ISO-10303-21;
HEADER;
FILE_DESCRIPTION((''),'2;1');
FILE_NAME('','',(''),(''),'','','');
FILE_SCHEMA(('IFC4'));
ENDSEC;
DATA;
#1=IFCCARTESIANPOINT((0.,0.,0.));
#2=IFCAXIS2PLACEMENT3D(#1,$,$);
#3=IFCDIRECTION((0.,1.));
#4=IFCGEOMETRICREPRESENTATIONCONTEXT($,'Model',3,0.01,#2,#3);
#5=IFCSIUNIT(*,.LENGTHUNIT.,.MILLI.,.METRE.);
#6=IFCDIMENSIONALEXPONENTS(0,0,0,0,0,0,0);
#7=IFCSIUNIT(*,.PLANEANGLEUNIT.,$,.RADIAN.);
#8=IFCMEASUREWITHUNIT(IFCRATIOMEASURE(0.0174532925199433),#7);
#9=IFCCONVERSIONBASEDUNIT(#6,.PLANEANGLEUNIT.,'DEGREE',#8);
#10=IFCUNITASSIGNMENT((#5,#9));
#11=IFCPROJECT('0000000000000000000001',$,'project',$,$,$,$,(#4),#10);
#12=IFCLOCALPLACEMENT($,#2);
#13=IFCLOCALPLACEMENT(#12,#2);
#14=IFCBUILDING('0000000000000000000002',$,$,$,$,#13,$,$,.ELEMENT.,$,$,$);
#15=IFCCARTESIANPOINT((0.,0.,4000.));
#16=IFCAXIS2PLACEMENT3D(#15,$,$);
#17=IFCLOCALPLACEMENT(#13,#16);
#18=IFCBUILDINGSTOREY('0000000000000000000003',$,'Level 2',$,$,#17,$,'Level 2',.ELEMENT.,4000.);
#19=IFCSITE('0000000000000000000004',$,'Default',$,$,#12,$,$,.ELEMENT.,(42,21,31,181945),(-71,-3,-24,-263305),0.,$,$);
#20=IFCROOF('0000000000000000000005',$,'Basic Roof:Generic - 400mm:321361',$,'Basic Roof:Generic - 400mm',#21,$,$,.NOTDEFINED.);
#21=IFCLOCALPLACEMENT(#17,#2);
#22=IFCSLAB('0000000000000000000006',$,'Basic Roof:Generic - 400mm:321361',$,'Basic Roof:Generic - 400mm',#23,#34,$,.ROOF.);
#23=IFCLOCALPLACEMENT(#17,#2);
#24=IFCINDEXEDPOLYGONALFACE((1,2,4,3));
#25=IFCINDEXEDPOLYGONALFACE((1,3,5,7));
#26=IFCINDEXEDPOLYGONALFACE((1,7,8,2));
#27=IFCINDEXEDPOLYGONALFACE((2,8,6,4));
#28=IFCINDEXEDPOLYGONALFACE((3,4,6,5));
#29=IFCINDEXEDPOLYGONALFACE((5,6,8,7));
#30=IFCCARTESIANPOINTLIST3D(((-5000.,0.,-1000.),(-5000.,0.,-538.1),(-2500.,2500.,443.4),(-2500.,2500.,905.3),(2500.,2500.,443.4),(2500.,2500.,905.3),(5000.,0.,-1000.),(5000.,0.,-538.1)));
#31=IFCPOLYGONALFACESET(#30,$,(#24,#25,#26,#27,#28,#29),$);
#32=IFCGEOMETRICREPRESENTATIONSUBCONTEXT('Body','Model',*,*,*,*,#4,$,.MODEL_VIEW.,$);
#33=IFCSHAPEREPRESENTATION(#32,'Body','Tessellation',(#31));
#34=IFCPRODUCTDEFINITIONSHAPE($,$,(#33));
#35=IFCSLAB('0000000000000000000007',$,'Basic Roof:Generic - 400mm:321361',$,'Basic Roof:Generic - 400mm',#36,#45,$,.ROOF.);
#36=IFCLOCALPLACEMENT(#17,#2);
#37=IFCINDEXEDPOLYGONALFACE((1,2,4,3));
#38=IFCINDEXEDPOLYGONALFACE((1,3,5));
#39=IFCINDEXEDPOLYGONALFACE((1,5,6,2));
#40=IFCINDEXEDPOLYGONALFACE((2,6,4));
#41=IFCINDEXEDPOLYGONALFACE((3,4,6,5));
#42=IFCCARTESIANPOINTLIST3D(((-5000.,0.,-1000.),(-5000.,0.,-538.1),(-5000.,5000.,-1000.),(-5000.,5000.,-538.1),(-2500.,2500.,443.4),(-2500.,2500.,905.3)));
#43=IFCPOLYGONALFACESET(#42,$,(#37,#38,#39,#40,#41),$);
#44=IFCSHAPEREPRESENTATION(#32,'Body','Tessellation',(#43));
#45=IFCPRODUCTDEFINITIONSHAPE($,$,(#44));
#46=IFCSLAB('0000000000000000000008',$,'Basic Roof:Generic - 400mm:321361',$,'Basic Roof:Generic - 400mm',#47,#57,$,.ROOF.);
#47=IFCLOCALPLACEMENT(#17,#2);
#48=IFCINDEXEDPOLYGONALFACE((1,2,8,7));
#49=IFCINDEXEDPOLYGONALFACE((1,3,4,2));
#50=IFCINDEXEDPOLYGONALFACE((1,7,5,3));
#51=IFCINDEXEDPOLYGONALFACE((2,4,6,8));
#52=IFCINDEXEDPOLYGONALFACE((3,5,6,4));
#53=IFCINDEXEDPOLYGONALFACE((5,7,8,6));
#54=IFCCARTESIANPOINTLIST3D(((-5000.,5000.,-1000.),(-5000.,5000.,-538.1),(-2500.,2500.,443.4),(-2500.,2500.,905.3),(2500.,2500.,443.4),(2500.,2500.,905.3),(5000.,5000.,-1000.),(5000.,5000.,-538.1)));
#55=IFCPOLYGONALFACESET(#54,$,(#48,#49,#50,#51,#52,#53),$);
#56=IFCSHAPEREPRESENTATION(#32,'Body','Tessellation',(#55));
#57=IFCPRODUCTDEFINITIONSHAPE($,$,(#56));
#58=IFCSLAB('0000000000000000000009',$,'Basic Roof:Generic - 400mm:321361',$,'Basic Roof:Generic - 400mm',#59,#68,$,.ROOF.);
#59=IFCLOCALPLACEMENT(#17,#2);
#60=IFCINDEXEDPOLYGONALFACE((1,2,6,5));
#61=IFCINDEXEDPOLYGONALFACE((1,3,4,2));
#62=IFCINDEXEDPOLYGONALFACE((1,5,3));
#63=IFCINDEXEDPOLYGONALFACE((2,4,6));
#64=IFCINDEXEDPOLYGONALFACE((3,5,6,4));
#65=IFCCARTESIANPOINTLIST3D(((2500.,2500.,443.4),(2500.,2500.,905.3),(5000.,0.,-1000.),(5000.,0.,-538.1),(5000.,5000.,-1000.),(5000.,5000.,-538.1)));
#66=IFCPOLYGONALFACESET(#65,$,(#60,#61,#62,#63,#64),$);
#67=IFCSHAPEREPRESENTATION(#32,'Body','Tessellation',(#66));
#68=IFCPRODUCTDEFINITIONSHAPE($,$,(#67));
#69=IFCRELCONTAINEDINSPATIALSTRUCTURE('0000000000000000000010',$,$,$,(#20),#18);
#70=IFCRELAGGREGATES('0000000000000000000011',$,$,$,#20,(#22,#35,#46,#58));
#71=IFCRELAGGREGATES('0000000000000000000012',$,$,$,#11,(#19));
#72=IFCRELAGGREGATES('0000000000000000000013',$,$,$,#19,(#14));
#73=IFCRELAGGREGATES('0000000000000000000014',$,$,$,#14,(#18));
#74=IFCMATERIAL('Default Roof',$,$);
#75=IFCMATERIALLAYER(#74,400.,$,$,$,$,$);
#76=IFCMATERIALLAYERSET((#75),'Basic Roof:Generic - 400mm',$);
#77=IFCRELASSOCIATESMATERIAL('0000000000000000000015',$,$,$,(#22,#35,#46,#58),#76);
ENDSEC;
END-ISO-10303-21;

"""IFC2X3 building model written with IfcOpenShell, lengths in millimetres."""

from ifc_helpers import new_model, entity, si_unit, converted_unit, direction, frame, origin, place, context, subcontext, project, spatial, polyline, outline, extrude, material, layer, layer_set, element, aggregate, save


model = new_model("IFC2X3")

# Units and contexts
model_context = context("Model", 3, precision=0.01, world=origin(), true_north=direction((0.0, 1.0)))
body_context = subcontext(model_context, "Body", "Model", "MODEL_VIEW")
ifc_project = project(units=[si_unit("LENGTHUNIT", "METRE", prefix="MILLI"), converted_unit("PLANEANGLEUNIT", "DEGREE", entity("IfcRatioMeasure", 0.0174532925199433), si_unit("PLANEANGLEUNIT", "RADIAN"), dimensions=[0, 0, 0, 0, 0, 0, 0])], contexts=[model_context])

# Site, building, storey
site_placement = place(None, origin())
site = spatial("IfcSite", under=ifc_project, at=site_placement, Name="Default", CompositionType="ELEMENT", RefLatitude=(42, 21, 31, 181945), RefLongitude=(-71, -3, -24, -263305), RefElevation=0.0)
building_placement = place(site_placement, origin())
building = spatial("IfcBuilding", under=site, at=building_placement, CompositionType="ELEMENT")
storey_placement = place(building_placement, frame((0.0, 0.0, 4000.0)))
storey = spatial("IfcBuildingStorey", under=building, at=storey_placement, Name="Level 2", LongName="Level 2", CompositionType="ELEMENT", Elevation=4000.0)

# Roof, slabs
roof_placement = place(storey_placement, frame((-5000.0, 0.0, -1000.0)))
roof = element("IfcRoof", 1, at=roof_placement, inside=storey, Name="Basic Roof:Generic - 400mm:321361", ObjectType="Basic Roof:Generic - 400mm", ShapeType="NOTDEFINED")
ifc_material = material(Name="Default Roof")
ifc_layer = layer(ifc_material, 400.0)
ifc_layer_set = layer_set([ifc_layer], Name="Basic Roof:Generic - 400mm")
slab_1_placement = place(roof_placement, origin())
slab_1 = element("IfcSlab", 2, at=slab_1_placement, material=ifc_layer_set, Name="Basic Roof:Generic - 400mm:321361", ObjectType="Basic Roof:Generic - 400mm", PredefinedType="ROOF", context=body_context, shape_type="SweptSolid", body=[
    extrude(outline(polyline([(2500.0, 1443.4), (-2500.0, 1443.4), (-5000.0, -1443.4), (5000.0, -1443.4), (2500.0, 1443.4)])), frame((5000.0, 1250.0, 721.7), z_axis=(0.0, -0.5, 0.866025), x_axis=(1.0, 0.0, 0.0)), (0.0, 0.5, 0.866025), 461.9),
])
slab_2_placement = place(roof_placement, origin())
slab_2 = element("IfcSlab", 3, at=slab_2_placement, material=ifc_layer_set, Name="Basic Roof:Generic - 400mm:321361", ObjectType="Basic Roof:Generic - 400mm", PredefinedType="ROOF", context=body_context, shape_type="SweptSolid", body=[
    extrude(outline(polyline([(-1443.4, 2500.0), (-1443.4, -2500.0), (1443.4, 0.0), (-1443.4, 2500.0)])), frame((1250.0, 2500.0, 721.7), z_axis=(-0.5, 0.0, 0.866025), x_axis=(0.866025, 0.0, 0.5)), (0.5, 0.0, 0.866025), 461.9),
])
slab_3_placement = place(roof_placement, origin())
slab_3 = element("IfcSlab", 4, at=slab_3_placement, material=ifc_layer_set, Name="Basic Roof:Generic - 400mm:321361", ObjectType="Basic Roof:Generic - 400mm", PredefinedType="ROOF", context=body_context, shape_type="SweptSolid", body=[
    extrude(outline(polyline([(5000.0, 1443.4), (-5000.0, 1443.4), (-2500.0, -1443.4), (2500.0, -1443.4), (5000.0, 1443.4)])), frame((5000.0, 3750.0, 721.7), z_axis=(0.0, 0.5, 0.866025), x_axis=(1.0, 0.0, 0.0)), (0.0, -0.5, 0.866025), 461.9),
])
slab_4_placement = place(roof_placement, origin())
slab_4 = element("IfcSlab", 5, at=slab_4_placement, material=ifc_layer_set, Name="Basic Roof:Generic - 400mm:321361", ObjectType="Basic Roof:Generic - 400mm", PredefinedType="ROOF", context=body_context, shape_type="SweptSolid", body=[
    extrude(outline(polyline([(1443.4, -2500.0), (1443.4, 2500.0), (-1443.4, 0.0), (1443.4, -2500.0)])), frame((8750.0, 2500.0, 721.7), z_axis=(0.5, 0.0, 0.866025), x_axis=(0.866025, 0.0, -0.5)), (-0.5, 0.0, 0.866025), 461.9),
])
aggregate(roof, [slab_1, slab_2, slab_3, slab_4])

save(model, "model.ifc")
